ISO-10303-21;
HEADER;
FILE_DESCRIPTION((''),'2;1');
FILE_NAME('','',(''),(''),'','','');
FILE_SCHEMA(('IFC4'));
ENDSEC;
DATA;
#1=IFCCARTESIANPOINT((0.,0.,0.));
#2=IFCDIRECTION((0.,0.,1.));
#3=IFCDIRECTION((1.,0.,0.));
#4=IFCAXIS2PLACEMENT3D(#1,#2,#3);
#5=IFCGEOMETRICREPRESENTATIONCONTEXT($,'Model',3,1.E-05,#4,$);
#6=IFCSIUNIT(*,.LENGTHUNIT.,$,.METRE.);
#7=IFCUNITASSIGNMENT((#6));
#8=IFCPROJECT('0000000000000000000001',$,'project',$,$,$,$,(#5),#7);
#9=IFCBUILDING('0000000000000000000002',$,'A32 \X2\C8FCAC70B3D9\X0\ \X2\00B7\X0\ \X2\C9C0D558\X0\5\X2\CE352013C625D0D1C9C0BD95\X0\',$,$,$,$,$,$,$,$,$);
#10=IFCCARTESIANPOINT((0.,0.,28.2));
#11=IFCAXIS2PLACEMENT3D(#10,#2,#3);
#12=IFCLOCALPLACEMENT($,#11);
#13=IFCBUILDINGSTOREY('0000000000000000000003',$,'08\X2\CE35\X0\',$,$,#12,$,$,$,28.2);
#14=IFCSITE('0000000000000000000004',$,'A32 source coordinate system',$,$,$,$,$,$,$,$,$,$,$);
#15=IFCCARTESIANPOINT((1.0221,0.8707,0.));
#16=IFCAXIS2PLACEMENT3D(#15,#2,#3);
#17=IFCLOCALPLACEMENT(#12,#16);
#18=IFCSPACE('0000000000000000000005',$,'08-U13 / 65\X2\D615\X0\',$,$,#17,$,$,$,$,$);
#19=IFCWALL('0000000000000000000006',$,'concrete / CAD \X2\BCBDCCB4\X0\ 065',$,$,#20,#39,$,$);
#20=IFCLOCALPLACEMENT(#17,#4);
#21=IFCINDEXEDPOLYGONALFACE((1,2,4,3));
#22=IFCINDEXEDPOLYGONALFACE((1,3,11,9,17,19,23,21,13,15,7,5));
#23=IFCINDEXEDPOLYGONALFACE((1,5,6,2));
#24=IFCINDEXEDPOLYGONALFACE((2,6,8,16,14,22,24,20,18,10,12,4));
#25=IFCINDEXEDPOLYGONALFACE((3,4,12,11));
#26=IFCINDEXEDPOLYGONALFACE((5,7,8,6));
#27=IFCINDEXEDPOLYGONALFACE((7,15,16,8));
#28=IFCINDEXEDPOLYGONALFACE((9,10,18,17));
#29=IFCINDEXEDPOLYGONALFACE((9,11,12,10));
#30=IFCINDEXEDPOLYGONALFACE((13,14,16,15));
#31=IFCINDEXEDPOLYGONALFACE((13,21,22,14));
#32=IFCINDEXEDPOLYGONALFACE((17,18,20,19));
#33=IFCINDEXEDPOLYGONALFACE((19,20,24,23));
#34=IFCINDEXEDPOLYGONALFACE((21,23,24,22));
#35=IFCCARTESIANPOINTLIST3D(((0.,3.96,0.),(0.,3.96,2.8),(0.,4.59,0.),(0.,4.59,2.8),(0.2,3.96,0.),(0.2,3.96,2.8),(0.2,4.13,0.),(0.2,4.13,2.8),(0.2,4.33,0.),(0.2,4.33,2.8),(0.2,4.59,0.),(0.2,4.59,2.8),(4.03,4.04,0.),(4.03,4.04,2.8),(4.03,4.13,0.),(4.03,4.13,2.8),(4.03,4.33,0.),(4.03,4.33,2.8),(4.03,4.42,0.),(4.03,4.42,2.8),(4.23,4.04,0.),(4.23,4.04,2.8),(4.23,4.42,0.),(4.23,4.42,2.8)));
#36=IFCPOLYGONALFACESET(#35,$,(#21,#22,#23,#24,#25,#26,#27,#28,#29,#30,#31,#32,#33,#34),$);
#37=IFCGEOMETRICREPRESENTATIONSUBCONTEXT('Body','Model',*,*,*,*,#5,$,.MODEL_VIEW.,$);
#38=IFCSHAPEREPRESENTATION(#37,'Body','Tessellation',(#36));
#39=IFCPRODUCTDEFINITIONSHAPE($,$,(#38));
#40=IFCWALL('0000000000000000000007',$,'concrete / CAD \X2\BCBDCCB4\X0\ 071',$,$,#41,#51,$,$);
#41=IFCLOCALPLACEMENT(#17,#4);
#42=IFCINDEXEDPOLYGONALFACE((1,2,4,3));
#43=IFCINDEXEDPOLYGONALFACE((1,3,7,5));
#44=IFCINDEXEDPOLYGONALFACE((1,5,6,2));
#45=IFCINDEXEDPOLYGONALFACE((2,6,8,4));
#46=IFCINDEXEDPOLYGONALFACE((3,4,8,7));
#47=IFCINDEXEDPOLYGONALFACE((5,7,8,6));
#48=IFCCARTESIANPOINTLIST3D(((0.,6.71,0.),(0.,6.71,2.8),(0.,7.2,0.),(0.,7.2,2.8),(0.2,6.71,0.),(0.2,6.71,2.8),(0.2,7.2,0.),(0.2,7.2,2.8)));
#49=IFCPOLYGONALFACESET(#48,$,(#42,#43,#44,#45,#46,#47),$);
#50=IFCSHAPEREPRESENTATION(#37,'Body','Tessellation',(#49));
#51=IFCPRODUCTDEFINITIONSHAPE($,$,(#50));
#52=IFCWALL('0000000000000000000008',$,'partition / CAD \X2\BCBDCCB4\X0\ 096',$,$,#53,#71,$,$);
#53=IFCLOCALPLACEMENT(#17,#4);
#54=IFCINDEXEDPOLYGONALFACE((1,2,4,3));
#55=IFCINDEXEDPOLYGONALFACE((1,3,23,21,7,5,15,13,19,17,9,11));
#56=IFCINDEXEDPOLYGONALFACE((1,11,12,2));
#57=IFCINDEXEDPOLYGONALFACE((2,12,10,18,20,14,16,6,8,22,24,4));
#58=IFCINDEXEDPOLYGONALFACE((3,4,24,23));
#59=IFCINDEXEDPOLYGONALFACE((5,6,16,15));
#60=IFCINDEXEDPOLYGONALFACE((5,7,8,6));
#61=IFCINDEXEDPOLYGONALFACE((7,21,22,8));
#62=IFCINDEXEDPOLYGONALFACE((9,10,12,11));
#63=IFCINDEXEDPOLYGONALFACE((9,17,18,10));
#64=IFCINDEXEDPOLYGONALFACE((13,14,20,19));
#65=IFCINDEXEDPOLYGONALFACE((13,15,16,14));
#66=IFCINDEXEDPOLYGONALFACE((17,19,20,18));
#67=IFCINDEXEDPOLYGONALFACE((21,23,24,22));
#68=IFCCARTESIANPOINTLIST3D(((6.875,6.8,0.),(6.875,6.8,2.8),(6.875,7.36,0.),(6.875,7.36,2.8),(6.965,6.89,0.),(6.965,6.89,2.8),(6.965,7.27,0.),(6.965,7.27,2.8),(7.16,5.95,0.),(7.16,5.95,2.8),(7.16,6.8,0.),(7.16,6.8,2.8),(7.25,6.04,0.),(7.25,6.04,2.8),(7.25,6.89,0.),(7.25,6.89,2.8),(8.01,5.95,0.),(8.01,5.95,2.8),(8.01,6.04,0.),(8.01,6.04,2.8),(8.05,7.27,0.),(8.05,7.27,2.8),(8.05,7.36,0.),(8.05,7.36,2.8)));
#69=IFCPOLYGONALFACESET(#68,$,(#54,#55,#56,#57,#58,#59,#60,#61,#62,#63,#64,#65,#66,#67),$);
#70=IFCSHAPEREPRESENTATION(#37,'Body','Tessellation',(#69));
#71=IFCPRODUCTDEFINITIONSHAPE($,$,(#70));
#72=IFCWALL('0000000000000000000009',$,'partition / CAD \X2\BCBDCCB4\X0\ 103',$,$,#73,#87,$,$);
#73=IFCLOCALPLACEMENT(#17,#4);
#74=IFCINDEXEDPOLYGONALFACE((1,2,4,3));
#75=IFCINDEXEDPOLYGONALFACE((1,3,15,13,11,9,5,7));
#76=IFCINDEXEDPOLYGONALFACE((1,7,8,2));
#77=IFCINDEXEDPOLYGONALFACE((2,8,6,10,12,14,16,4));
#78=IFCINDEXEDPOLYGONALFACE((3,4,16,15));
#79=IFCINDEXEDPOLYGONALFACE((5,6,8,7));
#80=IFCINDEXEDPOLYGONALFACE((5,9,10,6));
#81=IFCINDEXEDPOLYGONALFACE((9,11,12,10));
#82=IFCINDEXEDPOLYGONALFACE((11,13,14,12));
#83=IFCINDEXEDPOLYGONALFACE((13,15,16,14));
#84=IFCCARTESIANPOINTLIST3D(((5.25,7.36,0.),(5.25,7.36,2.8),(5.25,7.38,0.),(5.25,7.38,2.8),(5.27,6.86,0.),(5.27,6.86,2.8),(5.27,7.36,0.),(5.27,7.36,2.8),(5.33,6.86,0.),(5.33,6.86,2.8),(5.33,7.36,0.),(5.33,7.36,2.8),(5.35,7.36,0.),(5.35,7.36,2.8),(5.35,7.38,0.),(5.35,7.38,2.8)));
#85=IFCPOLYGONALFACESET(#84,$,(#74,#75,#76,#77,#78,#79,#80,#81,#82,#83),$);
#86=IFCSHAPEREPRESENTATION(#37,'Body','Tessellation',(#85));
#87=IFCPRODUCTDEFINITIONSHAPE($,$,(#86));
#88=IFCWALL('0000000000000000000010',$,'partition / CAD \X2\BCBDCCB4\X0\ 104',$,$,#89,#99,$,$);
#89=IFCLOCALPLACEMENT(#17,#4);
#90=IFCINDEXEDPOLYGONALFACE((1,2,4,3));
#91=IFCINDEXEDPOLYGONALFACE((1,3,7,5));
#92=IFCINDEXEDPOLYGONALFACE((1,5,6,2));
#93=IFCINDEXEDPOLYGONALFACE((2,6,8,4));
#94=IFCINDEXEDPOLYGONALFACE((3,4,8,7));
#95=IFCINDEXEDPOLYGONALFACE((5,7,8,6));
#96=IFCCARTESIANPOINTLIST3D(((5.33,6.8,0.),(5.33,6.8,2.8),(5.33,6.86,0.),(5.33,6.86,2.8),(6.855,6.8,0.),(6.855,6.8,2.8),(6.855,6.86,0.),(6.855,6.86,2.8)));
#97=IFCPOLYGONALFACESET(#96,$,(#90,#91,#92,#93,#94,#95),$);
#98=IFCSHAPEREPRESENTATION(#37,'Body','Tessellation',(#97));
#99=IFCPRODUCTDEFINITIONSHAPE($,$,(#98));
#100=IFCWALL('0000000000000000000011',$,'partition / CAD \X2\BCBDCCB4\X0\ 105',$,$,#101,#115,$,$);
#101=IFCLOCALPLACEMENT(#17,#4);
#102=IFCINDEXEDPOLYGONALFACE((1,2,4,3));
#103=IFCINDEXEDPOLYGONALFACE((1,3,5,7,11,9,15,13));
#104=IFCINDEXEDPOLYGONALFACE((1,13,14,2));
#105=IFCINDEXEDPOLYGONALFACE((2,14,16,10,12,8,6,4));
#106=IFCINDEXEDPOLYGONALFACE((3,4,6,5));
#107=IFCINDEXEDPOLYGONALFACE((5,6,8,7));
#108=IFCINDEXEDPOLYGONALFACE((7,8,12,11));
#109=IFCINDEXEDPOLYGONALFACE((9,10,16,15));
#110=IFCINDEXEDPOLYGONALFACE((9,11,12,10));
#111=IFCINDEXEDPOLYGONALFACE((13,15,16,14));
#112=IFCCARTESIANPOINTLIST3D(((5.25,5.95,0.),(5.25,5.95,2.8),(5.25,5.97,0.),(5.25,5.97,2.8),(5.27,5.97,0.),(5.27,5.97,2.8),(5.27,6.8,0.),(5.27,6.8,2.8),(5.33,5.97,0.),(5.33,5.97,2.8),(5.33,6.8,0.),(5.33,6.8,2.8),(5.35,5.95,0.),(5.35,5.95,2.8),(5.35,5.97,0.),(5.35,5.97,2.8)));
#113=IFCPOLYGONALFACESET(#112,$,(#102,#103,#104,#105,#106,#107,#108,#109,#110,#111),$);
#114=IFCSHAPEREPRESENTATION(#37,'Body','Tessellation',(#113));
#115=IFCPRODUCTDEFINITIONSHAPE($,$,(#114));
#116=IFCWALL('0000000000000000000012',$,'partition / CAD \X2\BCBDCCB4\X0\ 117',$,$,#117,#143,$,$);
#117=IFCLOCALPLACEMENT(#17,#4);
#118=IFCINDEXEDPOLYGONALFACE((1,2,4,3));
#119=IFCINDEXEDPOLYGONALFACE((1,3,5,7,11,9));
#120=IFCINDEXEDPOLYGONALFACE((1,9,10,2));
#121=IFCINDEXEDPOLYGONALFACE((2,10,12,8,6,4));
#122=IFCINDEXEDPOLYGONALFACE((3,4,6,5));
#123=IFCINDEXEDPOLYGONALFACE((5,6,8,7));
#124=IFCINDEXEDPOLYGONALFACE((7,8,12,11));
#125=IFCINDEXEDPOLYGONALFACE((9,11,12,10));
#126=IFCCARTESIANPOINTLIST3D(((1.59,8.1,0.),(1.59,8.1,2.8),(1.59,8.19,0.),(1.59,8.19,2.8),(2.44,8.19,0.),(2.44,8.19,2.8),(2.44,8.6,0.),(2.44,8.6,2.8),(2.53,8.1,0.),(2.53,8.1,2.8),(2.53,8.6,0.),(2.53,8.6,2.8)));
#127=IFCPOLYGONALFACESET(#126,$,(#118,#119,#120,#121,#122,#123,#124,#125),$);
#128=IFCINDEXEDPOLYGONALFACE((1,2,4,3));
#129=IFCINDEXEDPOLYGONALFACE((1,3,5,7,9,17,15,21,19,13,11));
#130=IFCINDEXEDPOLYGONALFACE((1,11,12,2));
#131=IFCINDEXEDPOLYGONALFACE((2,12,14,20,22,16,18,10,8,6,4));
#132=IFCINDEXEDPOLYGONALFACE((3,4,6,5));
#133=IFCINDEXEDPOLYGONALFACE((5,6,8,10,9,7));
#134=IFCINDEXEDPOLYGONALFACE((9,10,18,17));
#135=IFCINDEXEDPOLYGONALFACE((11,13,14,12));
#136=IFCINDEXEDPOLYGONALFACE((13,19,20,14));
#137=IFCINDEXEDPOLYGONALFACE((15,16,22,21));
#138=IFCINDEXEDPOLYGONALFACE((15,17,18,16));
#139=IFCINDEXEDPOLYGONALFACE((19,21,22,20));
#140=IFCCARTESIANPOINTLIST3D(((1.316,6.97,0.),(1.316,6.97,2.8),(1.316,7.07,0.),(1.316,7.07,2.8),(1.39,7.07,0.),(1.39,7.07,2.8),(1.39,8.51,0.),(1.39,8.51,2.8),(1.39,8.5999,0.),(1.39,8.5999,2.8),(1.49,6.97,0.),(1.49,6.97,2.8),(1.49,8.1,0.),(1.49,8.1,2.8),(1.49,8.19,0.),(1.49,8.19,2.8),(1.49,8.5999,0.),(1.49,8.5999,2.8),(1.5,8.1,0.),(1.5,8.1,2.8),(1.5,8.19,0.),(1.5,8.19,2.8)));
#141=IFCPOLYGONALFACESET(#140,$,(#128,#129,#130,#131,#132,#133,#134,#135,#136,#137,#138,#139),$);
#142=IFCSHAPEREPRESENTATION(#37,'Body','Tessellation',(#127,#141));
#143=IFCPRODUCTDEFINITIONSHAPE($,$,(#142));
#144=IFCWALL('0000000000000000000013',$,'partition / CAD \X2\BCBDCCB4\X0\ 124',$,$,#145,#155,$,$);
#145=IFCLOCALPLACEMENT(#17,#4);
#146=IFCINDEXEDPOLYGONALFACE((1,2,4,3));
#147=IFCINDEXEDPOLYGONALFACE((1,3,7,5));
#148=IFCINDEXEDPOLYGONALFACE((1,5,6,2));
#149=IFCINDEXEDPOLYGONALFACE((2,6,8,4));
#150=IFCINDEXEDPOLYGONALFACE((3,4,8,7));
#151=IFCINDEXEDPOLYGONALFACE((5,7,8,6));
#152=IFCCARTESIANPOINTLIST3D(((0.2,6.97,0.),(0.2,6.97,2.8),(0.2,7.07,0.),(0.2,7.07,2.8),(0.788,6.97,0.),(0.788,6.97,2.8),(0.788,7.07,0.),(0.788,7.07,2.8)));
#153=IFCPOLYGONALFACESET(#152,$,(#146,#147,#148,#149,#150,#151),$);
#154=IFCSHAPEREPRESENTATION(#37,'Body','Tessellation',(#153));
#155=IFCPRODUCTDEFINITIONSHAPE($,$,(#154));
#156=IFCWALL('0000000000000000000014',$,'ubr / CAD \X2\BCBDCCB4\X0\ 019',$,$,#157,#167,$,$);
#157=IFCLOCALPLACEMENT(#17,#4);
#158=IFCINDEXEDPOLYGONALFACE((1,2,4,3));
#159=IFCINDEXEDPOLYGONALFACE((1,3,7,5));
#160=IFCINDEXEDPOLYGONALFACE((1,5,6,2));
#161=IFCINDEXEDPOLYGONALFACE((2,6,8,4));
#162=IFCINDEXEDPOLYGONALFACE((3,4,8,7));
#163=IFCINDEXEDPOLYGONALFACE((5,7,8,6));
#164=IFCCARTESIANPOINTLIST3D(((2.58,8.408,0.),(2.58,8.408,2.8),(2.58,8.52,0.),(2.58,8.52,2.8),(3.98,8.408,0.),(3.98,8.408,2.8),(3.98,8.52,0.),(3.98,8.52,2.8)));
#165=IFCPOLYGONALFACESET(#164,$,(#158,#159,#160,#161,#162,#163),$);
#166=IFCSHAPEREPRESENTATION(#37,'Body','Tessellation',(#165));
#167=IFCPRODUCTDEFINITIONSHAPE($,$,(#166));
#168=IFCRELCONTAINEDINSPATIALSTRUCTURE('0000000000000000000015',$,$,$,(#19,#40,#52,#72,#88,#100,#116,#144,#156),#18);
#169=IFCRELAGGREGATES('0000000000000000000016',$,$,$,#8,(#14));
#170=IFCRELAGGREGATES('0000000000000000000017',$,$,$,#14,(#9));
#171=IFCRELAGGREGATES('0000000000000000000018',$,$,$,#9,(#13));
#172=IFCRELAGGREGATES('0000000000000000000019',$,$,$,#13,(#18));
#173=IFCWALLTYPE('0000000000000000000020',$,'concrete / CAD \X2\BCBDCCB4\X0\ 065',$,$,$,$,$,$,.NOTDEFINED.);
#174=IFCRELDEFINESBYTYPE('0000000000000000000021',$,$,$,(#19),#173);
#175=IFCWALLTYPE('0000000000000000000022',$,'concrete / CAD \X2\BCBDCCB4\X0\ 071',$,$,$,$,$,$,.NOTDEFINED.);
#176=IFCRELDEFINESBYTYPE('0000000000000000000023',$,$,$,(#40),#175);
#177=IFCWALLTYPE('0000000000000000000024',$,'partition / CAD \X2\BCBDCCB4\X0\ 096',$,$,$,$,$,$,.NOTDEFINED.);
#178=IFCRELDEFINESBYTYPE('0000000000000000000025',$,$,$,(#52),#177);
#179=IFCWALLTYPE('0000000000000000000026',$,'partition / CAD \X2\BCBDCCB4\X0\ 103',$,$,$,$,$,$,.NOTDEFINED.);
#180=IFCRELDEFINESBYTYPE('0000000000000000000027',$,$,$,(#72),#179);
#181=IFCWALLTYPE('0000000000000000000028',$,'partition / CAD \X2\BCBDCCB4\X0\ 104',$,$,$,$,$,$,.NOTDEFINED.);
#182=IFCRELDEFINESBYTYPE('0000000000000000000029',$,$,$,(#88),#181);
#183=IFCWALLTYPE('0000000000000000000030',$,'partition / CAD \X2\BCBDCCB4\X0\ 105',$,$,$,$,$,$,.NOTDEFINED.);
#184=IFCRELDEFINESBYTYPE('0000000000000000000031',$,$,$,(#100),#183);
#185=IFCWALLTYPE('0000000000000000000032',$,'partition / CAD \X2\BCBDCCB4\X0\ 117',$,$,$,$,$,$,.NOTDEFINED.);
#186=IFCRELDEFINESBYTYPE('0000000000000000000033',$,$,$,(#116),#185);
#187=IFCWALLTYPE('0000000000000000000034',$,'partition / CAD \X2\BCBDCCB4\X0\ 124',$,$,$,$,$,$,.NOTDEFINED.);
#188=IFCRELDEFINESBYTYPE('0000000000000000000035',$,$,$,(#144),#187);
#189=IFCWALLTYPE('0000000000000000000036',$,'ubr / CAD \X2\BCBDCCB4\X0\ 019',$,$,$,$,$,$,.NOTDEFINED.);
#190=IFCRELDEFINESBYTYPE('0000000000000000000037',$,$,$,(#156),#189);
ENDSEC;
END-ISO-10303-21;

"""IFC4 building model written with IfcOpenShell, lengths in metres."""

from ifc_helpers import new_model, si_unit, frame, origin, origin_with_axes, place, context, subcontext, project, spatial, polyline, outline, extrude, source, transform, mapped, type_object, type_shapes, element, save


model = new_model("IFC4")

# Units and contexts
model_context = context("Model", 3, precision=1e-05, world=origin_with_axes())
body_context = subcontext(model_context, "Body", "Model", "MODEL_VIEW")
ifc_project = project(units=[si_unit("LENGTHUNIT", "METRE")], contexts=[model_context])

# Site, building, storey, space
storey_placement = place(None, frame((0.0, 0.0, 28.2), z_axis=(0.0, 0.0, 1.0), x_axis=(1.0, 0.0, 0.0)))
space_placement = place(storey_placement, frame((1.0221, 0.8707, 0.0), z_axis=(0.0, 0.0, 1.0), x_axis=(1.0, 0.0, 0.0)))
site = spatial("IfcSite", under=ifc_project, Name="A32 source coordinate system")
building = spatial("IfcBuilding", under=site, Name="A32 주거동 · 지하5층–옥탑지붕")
storey = spatial("IfcBuildingStorey", under=building, at=storey_placement, Name="08층", Elevation=28.2)
space = spatial("IfcSpace", under=storey, at=space_placement, Name="08-U13 / 65형")

# Walls
wall_type_1 = type_object("IfcWallType", Name="concrete / CAD 벽체 065", PredefinedType="NOTDEFINED")
shared_shape_1 = source(origin(), body_context, "Body", "SweptSolid", [
    extrude(outline(polyline([(0.2, 4.59), (0.2, 4.33), (4.03, 4.33), (4.03, 4.42), (4.23, 4.42), (4.23, 4.04), (4.03, 4.04), (4.03, 4.13), (0.2, 4.13), (0.2, 3.96), (0.0, 3.96), (0.0, 4.59), (0.2, 4.59)])), origin(), (0.0, 0.0, 1.0), 2.8),
])
type_shapes(wall_type_1, [shared_shape_1])
wall_1_placement = place(space_placement, origin_with_axes())
element("IfcWall", 1, at=wall_1_placement, inside=space, type_object=wall_type_1, Name="concrete / CAD 벽체 065", context=body_context, shape_type="MappedRepresentation", body=[
    mapped(shared_shape_1, transform((0.0, 0.0, 0.0), scale=1.0)),
])
wall_type_2 = type_object("IfcWallType", Name="concrete / CAD 벽체 071", PredefinedType="NOTDEFINED")
shared_shape_2 = source(origin(), body_context, "Body", "SweptSolid", [
    extrude(outline(polyline([(0.2, 6.71), (0.0, 6.71), (0.0, 7.2), (0.2, 7.2), (0.2, 6.71)])), origin(), (0.0, 0.0, 1.0), 2.8),
])
type_shapes(wall_type_2, [shared_shape_2])
wall_2_placement = place(space_placement, origin_with_axes())
element("IfcWall", 2, at=wall_2_placement, inside=space, type_object=wall_type_2, Name="concrete / CAD 벽체 071", context=body_context, shape_type="MappedRepresentation", body=[
    mapped(shared_shape_2, transform((0.0, 0.0, 0.0), scale=1.0)),
])
wall_type_3 = type_object("IfcWallType", Name="partition / CAD 벽체 096", PredefinedType="NOTDEFINED")
shared_shape_3 = source(origin(), body_context, "Body", "SweptSolid", [
    extrude(outline(polyline([(7.25, 6.04), (8.01, 6.04), (8.01, 5.95), (7.16, 5.95), (7.16, 6.8), (6.875, 6.8), (6.875, 7.36), (8.05, 7.36), (8.05, 7.27), (6.965, 7.27), (6.965, 6.89), (7.25, 6.89), (7.25, 6.04)])), origin(), (0.0, 0.0, 1.0), 2.8),
])
type_shapes(wall_type_3, [shared_shape_3])
wall_3_placement = place(space_placement, origin_with_axes())
element("IfcWall", 3, at=wall_3_placement, inside=space, type_object=wall_type_3, Name="partition / CAD 벽체 096", context=body_context, shape_type="MappedRepresentation", body=[
    mapped(shared_shape_3, transform((0.0, 0.0, 0.0), scale=1.0)),
])
wall_type_4 = type_object("IfcWallType", Name="partition / CAD 벽체 103", PredefinedType="NOTDEFINED")
shared_shape_4 = source(origin(), body_context, "Body", "SweptSolid", [
    extrude(outline(polyline([(5.27, 7.36), (5.25, 7.36), (5.25, 7.38), (5.35, 7.38), (5.35, 7.36), (5.33, 7.36), (5.33, 6.86), (5.27, 6.86), (5.27, 7.36)])), origin(), (0.0, 0.0, 1.0), 2.8),
])
type_shapes(wall_type_4, [shared_shape_4])
wall_4_placement = place(space_placement, origin_with_axes())
element("IfcWall", 4, at=wall_4_placement, inside=space, type_object=wall_type_4, Name="partition / CAD 벽체 103", context=body_context, shape_type="MappedRepresentation", body=[
    mapped(shared_shape_4, transform((0.0, 0.0, 0.0), scale=1.0)),
])
wall_type_5 = type_object("IfcWallType", Name="partition / CAD 벽체 104", PredefinedType="NOTDEFINED")
shared_shape_5 = source(origin(), body_context, "Body", "SweptSolid", [
    extrude(outline(polyline([(6.855, 6.86), (6.855, 6.8), (5.33, 6.8), (5.33, 6.86), (6.855, 6.86)])), origin(), (0.0, 0.0, 1.0), 2.8),
])
type_shapes(wall_type_5, [shared_shape_5])
wall_5_placement = place(space_placement, origin_with_axes())
element("IfcWall", 5, at=wall_5_placement, inside=space, type_object=wall_type_5, Name="partition / CAD 벽체 104", context=body_context, shape_type="MappedRepresentation", body=[
    mapped(shared_shape_5, transform((0.0, 0.0, 0.0), scale=1.0)),
])
wall_type_6 = type_object("IfcWallType", Name="partition / CAD 벽체 105", PredefinedType="NOTDEFINED")
shared_shape_6 = source(origin(), body_context, "Body", "SweptSolid", [
    extrude(outline(polyline([(5.25, 5.97), (5.27, 5.97), (5.27, 6.8), (5.33, 6.8), (5.33, 5.97), (5.35, 5.97), (5.35, 5.95), (5.25, 5.95), (5.25, 5.97)])), origin(), (0.0, 0.0, 1.0), 2.8),
])
type_shapes(wall_type_6, [shared_shape_6])
wall_6_placement = place(space_placement, origin_with_axes())
element("IfcWall", 6, at=wall_6_placement, inside=space, type_object=wall_type_6, Name="partition / CAD 벽체 105", context=body_context, shape_type="MappedRepresentation", body=[
    mapped(shared_shape_6, transform((0.0, 0.0, 0.0), scale=1.0)),
])
wall_type_7 = type_object("IfcWallType", Name="partition / CAD 벽체 117", PredefinedType="NOTDEFINED")
shared_shape_7 = source(origin(), body_context, "Body", "SweptSolid", [
    extrude(outline(polyline([(2.53, 8.1), (1.59, 8.1), (1.59, 8.19), (2.44, 8.19), (2.44, 8.6), (2.53, 8.6), (2.53, 8.1)])), origin(), (0.0, 0.0, 1.0), 2.8),
    extrude(outline(polyline([(1.49, 8.1), (1.49, 6.97), (1.316, 6.97), (1.316, 7.07), (1.39, 7.07), (1.39, 8.51), (1.39, 8.5999), (1.49, 8.5999), (1.49, 8.19), (1.5, 8.19), (1.5, 8.1), (1.49, 8.1)])), origin(), (0.0, 0.0, 1.0), 2.8),
])
type_shapes(wall_type_7, [shared_shape_7])
wall_7_placement = place(space_placement, origin_with_axes())
element("IfcWall", 7, at=wall_7_placement, inside=space, type_object=wall_type_7, Name="partition / CAD 벽체 117", context=body_context, shape_type="MappedRepresentation", body=[
    mapped(shared_shape_7, transform((0.0, 0.0, 0.0), scale=1.0)),
])
wall_type_8 = type_object("IfcWallType", Name="partition / CAD 벽체 124", PredefinedType="NOTDEFINED")
shared_shape_8 = source(origin(), body_context, "Body", "SweptSolid", [
    extrude(outline(polyline([(0.788, 7.07), (0.788, 6.97), (0.2, 6.97), (0.2, 7.07), (0.788, 7.07)])), origin(), (0.0, 0.0, 1.0), 2.8),
])
type_shapes(wall_type_8, [shared_shape_8])
wall_8_placement = place(space_placement, origin_with_axes())
element("IfcWall", 8, at=wall_8_placement, inside=space, type_object=wall_type_8, Name="partition / CAD 벽체 124", context=body_context, shape_type="MappedRepresentation", body=[
    mapped(shared_shape_8, transform((0.0, 0.0, 0.0), scale=1.0)),
])
wall_type_9 = type_object("IfcWallType", Name="ubr / CAD 벽체 019", PredefinedType="NOTDEFINED")
shared_shape_9 = source(origin(), body_context, "Body", "SweptSolid", [
    extrude(outline(polyline([(3.98, 8.408), (2.58, 8.408), (2.58, 8.52), (3.98, 8.52), (3.98, 8.408)])), origin(), (0.0, 0.0, 1.0), 2.8),
])
type_shapes(wall_type_9, [shared_shape_9])
wall_9_placement = place(space_placement, origin_with_axes())
element("IfcWall", 9, at=wall_9_placement, inside=space, type_object=wall_type_9, Name="ubr / CAD 벽체 019", context=body_context, shape_type="MappedRepresentation", body=[
    mapped(shared_shape_9, transform((0.0, 0.0, 0.0), scale=1.0)),
])

save(model, "model.ifc")
